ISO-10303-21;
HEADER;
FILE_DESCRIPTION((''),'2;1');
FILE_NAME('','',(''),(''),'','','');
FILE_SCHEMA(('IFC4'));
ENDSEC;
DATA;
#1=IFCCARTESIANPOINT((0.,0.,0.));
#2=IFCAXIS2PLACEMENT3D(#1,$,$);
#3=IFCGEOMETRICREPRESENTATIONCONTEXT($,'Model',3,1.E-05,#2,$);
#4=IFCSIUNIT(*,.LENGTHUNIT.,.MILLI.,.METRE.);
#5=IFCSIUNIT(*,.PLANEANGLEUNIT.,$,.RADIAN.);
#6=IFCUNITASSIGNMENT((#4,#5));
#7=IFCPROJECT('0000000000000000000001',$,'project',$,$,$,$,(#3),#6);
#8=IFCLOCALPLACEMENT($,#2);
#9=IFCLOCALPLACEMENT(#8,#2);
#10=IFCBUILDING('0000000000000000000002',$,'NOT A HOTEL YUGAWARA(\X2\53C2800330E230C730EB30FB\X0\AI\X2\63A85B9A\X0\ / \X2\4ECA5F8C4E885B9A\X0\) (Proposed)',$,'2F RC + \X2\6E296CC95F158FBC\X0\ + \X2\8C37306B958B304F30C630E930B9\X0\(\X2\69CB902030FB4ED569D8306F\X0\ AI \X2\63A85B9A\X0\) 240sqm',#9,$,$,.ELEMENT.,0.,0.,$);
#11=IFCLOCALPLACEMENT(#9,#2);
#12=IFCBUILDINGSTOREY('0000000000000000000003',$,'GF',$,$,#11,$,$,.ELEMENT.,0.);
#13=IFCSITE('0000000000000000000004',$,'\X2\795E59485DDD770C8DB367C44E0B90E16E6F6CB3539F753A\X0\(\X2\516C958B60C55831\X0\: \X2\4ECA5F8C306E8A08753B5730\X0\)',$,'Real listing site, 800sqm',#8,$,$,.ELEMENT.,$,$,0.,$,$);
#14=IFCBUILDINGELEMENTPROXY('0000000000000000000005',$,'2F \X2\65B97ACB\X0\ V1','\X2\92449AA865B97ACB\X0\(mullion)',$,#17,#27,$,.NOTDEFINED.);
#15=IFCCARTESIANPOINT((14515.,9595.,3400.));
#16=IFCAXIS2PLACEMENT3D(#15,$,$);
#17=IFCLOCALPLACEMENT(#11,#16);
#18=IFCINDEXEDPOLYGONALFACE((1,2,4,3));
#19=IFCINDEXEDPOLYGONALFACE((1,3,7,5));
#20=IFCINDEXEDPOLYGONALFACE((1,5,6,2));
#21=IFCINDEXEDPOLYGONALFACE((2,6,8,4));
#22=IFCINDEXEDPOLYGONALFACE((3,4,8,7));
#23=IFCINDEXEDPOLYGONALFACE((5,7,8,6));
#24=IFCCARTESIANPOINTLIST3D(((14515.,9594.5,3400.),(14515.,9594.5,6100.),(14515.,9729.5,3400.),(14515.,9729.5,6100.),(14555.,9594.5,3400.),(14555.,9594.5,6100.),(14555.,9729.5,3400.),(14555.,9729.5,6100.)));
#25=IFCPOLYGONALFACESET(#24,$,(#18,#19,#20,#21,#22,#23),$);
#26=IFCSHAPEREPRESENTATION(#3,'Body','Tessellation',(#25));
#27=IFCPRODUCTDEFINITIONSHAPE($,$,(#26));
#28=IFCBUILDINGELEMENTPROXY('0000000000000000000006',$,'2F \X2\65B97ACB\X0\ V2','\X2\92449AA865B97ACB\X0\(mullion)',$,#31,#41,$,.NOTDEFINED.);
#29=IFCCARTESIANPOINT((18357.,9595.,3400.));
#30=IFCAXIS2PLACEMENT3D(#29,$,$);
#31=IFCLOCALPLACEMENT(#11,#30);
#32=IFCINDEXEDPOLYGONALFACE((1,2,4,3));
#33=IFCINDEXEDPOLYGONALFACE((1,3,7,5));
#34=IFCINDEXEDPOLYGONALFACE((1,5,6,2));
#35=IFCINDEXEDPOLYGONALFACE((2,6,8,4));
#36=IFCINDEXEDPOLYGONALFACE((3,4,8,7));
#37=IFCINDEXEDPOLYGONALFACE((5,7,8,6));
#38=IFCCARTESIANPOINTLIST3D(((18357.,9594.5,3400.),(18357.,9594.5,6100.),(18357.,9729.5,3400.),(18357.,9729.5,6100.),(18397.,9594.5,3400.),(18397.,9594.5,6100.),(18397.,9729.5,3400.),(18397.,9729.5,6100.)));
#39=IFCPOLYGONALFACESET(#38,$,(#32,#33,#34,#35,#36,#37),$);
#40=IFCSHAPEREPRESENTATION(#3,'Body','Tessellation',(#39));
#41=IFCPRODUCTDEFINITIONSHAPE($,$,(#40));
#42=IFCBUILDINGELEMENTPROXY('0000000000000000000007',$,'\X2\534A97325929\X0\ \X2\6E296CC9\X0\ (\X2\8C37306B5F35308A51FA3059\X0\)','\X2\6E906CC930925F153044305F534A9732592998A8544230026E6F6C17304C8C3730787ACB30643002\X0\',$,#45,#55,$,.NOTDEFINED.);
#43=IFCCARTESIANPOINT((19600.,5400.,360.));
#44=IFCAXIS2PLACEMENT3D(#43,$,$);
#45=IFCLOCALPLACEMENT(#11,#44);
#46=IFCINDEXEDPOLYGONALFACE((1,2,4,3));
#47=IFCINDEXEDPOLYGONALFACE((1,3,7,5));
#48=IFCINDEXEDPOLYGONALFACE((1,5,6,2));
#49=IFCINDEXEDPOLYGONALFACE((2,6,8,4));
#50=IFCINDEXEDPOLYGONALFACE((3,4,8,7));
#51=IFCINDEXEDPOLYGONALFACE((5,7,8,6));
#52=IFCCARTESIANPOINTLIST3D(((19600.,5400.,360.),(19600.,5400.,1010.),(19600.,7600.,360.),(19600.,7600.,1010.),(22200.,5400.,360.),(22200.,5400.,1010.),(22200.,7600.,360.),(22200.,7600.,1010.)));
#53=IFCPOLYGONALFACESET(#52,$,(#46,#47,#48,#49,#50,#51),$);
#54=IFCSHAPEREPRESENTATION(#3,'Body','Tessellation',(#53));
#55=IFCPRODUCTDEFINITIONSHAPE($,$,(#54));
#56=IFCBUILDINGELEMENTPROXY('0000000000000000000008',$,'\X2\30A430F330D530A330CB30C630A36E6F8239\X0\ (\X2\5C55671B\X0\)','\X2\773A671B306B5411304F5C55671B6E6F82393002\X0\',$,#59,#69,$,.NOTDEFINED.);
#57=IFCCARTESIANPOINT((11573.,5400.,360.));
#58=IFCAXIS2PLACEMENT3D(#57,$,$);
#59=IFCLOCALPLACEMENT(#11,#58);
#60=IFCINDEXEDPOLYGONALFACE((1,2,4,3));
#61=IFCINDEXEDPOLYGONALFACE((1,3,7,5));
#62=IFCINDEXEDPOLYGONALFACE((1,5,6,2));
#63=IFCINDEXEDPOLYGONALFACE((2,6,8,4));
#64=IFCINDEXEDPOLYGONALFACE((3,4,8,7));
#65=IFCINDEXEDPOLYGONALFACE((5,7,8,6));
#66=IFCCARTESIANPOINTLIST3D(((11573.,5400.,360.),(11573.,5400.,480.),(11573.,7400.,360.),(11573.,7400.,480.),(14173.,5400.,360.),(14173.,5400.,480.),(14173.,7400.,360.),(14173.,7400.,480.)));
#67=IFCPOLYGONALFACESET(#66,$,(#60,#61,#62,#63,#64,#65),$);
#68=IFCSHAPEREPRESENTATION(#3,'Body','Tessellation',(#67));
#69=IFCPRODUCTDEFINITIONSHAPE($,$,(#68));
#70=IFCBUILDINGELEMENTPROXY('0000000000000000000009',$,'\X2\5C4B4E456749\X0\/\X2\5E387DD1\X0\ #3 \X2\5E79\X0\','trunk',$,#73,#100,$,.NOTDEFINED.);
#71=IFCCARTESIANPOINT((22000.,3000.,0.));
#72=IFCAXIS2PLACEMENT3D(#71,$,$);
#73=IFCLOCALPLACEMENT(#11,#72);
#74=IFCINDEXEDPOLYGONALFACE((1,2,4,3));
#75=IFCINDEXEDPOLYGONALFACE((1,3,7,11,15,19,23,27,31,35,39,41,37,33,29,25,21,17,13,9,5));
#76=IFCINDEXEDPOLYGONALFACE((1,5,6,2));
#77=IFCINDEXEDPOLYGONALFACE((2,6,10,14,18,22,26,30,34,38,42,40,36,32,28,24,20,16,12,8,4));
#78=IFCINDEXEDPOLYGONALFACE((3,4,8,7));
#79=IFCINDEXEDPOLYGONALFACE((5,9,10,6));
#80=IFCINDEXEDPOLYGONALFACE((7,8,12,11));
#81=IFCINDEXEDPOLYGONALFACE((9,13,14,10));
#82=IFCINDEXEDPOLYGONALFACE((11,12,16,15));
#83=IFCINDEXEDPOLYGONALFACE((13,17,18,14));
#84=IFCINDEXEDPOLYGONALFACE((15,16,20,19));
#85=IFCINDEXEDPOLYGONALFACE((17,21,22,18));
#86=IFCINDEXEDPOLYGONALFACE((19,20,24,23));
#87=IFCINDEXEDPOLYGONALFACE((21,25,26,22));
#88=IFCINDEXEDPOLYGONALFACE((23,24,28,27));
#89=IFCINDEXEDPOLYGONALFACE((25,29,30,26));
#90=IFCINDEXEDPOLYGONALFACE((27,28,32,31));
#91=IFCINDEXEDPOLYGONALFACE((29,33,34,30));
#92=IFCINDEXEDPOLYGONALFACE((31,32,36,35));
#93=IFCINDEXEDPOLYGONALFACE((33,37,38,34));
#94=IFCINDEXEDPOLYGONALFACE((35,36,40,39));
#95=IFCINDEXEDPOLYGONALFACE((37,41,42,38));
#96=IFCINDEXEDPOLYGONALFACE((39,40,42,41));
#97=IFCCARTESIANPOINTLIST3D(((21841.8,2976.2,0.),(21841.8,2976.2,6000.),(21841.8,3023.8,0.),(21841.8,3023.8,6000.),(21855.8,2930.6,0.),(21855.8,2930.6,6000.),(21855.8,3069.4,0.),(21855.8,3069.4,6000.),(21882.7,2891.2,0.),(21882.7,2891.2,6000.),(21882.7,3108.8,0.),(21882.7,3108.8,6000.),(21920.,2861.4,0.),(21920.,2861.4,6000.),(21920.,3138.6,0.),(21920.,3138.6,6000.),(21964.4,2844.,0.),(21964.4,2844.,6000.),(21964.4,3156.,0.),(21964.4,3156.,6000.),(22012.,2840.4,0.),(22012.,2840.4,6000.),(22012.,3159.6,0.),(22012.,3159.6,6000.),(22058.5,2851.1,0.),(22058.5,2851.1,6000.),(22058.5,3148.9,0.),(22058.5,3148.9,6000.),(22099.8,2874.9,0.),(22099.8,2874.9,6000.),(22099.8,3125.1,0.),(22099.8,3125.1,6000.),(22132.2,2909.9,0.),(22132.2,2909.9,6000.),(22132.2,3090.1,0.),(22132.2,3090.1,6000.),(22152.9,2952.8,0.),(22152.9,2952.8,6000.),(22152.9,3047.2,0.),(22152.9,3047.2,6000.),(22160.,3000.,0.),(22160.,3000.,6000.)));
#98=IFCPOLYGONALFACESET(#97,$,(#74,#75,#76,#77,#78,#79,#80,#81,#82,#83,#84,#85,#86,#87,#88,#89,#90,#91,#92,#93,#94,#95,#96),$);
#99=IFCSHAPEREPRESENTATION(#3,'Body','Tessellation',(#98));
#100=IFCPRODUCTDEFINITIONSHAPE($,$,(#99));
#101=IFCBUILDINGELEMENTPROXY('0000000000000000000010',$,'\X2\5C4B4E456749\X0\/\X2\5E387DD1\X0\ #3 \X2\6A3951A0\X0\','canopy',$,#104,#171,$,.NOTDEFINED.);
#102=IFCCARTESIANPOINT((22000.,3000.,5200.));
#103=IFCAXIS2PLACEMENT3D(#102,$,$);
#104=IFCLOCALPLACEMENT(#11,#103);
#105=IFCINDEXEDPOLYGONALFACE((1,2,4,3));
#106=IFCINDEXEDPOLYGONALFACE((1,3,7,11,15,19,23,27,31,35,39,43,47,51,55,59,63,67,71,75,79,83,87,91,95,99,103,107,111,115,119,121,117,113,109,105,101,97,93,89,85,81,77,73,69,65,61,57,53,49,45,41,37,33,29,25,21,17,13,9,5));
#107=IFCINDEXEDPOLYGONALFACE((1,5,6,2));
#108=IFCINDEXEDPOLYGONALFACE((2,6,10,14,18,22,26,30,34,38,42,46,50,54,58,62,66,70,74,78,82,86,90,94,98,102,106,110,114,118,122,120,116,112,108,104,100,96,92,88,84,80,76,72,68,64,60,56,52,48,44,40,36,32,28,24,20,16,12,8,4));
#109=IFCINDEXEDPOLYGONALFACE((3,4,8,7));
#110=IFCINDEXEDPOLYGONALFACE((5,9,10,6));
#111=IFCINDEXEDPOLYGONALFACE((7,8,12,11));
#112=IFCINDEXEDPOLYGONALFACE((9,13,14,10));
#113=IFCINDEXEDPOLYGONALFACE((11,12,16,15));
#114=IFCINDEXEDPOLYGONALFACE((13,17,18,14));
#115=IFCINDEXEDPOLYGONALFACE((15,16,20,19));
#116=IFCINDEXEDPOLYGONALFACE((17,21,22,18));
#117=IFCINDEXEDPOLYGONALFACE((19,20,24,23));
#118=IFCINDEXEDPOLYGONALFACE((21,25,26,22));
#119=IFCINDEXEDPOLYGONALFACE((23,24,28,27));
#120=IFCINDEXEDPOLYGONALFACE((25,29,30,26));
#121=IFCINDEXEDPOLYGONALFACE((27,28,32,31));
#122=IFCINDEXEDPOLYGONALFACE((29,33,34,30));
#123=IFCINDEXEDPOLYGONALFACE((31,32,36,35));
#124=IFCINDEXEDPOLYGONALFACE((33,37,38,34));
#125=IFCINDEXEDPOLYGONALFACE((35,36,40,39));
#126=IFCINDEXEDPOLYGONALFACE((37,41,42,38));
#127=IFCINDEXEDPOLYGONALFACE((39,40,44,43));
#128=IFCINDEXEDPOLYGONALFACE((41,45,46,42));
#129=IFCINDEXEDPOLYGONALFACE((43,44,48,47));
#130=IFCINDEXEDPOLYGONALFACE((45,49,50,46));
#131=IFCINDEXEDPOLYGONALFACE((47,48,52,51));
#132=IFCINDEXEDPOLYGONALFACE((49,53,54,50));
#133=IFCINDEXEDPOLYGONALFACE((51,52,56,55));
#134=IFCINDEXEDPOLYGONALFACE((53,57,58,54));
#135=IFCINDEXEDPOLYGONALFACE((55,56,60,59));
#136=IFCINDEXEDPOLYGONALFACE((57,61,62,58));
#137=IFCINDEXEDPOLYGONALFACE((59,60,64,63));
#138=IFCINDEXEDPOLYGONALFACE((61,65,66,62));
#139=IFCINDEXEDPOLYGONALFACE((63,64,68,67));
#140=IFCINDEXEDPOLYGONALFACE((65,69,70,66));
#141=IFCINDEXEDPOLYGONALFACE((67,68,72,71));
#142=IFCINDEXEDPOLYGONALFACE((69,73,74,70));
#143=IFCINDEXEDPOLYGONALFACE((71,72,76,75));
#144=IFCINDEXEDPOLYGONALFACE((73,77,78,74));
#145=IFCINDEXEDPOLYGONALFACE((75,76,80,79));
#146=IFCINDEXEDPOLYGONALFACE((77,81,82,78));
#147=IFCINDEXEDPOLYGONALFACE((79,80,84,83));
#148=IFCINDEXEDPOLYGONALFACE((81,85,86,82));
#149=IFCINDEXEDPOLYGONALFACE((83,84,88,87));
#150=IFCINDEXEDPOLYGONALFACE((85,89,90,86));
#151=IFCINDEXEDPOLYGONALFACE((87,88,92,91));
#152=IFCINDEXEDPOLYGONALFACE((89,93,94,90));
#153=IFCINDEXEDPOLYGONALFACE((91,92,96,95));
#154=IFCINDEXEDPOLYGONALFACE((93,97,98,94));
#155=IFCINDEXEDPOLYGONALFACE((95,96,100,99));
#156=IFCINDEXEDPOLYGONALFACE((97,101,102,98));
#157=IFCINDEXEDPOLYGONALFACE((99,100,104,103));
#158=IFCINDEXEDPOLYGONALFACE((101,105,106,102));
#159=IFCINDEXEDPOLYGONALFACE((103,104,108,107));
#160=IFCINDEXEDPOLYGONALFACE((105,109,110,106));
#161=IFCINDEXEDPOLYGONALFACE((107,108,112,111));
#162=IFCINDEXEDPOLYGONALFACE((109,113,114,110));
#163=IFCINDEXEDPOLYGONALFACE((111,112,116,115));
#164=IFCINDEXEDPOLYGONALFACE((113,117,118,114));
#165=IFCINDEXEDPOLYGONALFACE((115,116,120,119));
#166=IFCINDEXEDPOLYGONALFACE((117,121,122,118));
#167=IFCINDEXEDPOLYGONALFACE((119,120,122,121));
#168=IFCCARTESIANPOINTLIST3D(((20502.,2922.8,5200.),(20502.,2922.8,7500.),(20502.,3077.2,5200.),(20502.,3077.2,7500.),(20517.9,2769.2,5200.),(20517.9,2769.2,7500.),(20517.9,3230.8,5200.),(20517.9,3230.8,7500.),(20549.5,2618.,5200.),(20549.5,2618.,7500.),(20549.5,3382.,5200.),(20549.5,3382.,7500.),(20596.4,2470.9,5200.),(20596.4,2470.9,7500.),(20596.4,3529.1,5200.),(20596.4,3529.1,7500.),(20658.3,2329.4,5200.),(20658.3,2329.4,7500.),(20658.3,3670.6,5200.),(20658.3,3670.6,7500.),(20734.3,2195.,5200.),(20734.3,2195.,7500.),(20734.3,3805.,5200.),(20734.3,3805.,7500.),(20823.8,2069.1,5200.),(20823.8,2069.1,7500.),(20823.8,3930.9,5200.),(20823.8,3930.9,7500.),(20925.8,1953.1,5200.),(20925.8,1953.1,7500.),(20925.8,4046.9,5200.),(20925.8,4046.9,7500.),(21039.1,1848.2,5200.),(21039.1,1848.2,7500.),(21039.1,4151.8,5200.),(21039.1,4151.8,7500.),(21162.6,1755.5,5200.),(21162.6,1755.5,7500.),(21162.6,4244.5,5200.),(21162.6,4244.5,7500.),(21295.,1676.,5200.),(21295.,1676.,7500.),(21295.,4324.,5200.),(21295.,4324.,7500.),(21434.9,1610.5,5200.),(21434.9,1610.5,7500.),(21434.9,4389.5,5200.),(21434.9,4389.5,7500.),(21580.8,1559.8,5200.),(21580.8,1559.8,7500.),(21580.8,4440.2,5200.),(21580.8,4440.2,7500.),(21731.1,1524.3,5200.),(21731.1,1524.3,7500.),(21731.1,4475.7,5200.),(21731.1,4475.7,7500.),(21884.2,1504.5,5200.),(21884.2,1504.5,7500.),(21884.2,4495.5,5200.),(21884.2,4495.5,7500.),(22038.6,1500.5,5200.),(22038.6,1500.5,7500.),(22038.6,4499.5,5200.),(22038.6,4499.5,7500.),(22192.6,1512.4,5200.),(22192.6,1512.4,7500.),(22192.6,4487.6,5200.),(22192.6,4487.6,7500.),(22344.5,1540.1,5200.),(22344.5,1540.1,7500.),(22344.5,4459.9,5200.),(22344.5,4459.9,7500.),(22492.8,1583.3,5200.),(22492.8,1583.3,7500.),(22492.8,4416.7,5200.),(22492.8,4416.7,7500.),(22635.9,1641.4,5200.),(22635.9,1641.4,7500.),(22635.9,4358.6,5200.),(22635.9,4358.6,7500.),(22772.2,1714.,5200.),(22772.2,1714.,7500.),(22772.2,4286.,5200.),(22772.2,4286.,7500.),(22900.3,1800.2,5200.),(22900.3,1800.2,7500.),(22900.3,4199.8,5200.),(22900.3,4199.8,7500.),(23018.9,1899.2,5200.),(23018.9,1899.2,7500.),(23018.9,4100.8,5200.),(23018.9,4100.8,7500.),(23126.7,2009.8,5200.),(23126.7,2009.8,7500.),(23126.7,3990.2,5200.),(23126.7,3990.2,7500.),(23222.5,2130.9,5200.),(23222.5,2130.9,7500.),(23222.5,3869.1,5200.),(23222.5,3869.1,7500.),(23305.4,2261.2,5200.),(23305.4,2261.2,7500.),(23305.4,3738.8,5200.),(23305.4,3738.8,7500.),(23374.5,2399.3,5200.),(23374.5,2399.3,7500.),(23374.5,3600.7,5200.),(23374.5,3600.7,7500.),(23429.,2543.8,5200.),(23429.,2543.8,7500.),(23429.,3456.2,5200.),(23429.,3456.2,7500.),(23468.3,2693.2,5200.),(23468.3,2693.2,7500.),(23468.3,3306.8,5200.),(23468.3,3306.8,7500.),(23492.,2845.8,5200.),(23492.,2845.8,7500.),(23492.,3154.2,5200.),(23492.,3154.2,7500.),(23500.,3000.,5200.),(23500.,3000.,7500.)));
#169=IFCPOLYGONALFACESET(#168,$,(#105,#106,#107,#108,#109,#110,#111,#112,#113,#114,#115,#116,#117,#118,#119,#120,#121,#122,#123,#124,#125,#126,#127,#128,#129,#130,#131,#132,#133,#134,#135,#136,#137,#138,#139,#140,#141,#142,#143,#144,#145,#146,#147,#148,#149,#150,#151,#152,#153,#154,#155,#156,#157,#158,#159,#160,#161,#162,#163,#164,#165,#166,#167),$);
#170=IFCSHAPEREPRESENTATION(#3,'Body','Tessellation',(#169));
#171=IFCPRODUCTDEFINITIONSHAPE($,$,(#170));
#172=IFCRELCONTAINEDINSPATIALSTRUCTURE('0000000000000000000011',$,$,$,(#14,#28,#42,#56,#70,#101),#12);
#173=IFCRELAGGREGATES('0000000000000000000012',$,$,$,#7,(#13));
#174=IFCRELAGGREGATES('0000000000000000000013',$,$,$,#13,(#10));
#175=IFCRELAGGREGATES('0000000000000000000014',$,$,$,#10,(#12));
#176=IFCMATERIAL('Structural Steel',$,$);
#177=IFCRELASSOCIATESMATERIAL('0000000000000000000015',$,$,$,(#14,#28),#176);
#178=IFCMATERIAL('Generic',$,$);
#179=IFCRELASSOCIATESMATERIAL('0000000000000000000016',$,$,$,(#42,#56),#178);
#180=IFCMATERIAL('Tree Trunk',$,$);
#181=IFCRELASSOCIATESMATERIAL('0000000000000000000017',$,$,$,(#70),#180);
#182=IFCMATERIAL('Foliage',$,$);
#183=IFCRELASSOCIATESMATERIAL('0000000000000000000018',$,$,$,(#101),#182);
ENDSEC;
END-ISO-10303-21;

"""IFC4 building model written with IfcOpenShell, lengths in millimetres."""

from ifc_helpers import new_model, si_unit, frame, frame_2d, origin, origin_2d, place, context, project, spatial, rectangle, circle, extrude, material, element, save


model = new_model("IFC4")

# Units and contexts
model_context = context("Model", 3, precision=1e-05, world=origin())
ifc_project = project(units=[si_unit("LENGTHUNIT", "METRE", prefix="MILLI"), si_unit("PLANEANGLEUNIT", "RADIAN")], contexts=[model_context])

# Site, building, storey
site_placement = place(None, origin())
site = spatial("IfcSite", under=ifc_project, at=site_placement, Name="神奈川県足柄下郡湯河原町(公開情報: 今後の計画地)", ObjectType="Real listing site, 800sqm", CompositionType="ELEMENT", RefElevation=0.0)
building_placement = place(site_placement, origin())
building = spatial("IfcBuilding", under=site, at=building_placement, Name="NOT A HOTEL YUGAWARA(参考モデル・AI推定 / 今後予定) (Proposed)", ObjectType="2F RC + 温泉引込 + 谷に開くテラス(構造・仕様は AI 推定) 240sqm", CompositionType="ELEMENT", ElevationOfRefHeight=0.0, ElevationOfTerrain=0.0)
storey_placement = place(building_placement, origin())
storey = spatial("IfcBuildingStorey", under=building, at=storey_placement, Name="GF", CompositionType="ELEMENT", Elevation=0.0)

# Shared definitions
ifc_material_1 = material(Name="Generic")

# Building element proxies
ifc_material_2 = material(Name="Structural Steel")
proxy_1_placement = place(storey_placement, frame((14515.0, 9595.0, 3400.0)))
element("IfcBuildingElementProxy", 1, at=proxy_1_placement, inside=storey, material=ifc_material_2, Name="2F 方立 V1", Description="鉄骨方立(mullion)", PredefinedType="NOTDEFINED", context=model_context, shape_type="SweptSolid", body=[
    extrude(rectangle(XDim=40.0, YDim=135.0, at=frame_2d((20.0, 67.0))), frame((14515.0, 9595.0, 3400.0)), (0.0, 0.0, 1.0), 2700.0),
])
proxy_2_placement = place(storey_placement, frame((18357.0, 9595.0, 3400.0)))
element("IfcBuildingElementProxy", 2, at=proxy_2_placement, inside=storey, material=ifc_material_2, Name="2F 方立 V2", Description="鉄骨方立(mullion)", PredefinedType="NOTDEFINED", context=model_context, shape_type="SweptSolid", body=[
    extrude(rectangle(XDim=40.0, YDim=135.0, at=frame_2d((20.0, 67.0))), frame((18357.0, 9595.0, 3400.0)), (0.0, 0.0, 1.0), 2700.0),
])
proxy_3_placement = place(storey_placement, frame((19600.0, 5400.0, 360.0)))
element("IfcBuildingElementProxy", 3, at=proxy_3_placement, inside=storey, material=ifc_material_1, Name="半露天 温泉 (谷に張り出す)", Description="源泉を引いた半露天風呂。湯気が谷へ立つ。", PredefinedType="NOTDEFINED", context=model_context, shape_type="SweptSolid", body=[
    extrude(rectangle(XDim=2600.0, YDim=2200.0, at=frame_2d((1300.0, 1100.0))), frame((19600.0, 5400.0, 360.0)), (0.0, 0.0, 1.0), 650.0),
])
proxy_4_placement = place(storey_placement, frame((11573.0, 5400.0, 360.0)))
element("IfcBuildingElementProxy", 4, at=proxy_4_placement, inside=storey, material=ifc_material_1, Name="インフィニティ湯船 (展望)", Description="眺望に向く展望湯船。", PredefinedType="NOTDEFINED", context=model_context, shape_type="SweptSolid", body=[
    extrude(rectangle(XDim=2600.0, YDim=2000.0, at=frame_2d((1300.0, 1000.0))), frame((11573.0, 5400.0, 360.0)), (0.0, 0.0, 1.0), 120.0),
])
ifc_material_3 = material(Name="Tree Trunk")
proxy_5_placement = place(storey_placement, frame((22000.0, 3000.0, 0.0)))
element("IfcBuildingElementProxy", 5, at=proxy_5_placement, inside=storey, material=ifc_material_3, Name="屋久杉/常緑 #3 幹", Description="trunk", PredefinedType="NOTDEFINED", context=model_context, shape_type="SweptSolid", body=[
    extrude(circle(Radius=160.0, at=origin_2d()), frame((22000.0, 3000.0, 0.0)), (0.0, 0.0, 1.0), 6000.0),
])
ifc_material_4 = material(Name="Foliage")
proxy_6_placement = place(storey_placement, frame((22000.0, 3000.0, 5200.0)))
element("IfcBuildingElementProxy", 6, at=proxy_6_placement, inside=storey, material=ifc_material_4, Name="屋久杉/常緑 #3 樹冠", Description="canopy", PredefinedType="NOTDEFINED", context=model_context, shape_type="SweptSolid", body=[
    extrude(circle(Radius=1500.0, at=origin_2d()), frame((22000.0, 3000.0, 5200.0)), (0.0, 0.0, 1.0), 2300.0),
])

save(model, "model.ifc")
